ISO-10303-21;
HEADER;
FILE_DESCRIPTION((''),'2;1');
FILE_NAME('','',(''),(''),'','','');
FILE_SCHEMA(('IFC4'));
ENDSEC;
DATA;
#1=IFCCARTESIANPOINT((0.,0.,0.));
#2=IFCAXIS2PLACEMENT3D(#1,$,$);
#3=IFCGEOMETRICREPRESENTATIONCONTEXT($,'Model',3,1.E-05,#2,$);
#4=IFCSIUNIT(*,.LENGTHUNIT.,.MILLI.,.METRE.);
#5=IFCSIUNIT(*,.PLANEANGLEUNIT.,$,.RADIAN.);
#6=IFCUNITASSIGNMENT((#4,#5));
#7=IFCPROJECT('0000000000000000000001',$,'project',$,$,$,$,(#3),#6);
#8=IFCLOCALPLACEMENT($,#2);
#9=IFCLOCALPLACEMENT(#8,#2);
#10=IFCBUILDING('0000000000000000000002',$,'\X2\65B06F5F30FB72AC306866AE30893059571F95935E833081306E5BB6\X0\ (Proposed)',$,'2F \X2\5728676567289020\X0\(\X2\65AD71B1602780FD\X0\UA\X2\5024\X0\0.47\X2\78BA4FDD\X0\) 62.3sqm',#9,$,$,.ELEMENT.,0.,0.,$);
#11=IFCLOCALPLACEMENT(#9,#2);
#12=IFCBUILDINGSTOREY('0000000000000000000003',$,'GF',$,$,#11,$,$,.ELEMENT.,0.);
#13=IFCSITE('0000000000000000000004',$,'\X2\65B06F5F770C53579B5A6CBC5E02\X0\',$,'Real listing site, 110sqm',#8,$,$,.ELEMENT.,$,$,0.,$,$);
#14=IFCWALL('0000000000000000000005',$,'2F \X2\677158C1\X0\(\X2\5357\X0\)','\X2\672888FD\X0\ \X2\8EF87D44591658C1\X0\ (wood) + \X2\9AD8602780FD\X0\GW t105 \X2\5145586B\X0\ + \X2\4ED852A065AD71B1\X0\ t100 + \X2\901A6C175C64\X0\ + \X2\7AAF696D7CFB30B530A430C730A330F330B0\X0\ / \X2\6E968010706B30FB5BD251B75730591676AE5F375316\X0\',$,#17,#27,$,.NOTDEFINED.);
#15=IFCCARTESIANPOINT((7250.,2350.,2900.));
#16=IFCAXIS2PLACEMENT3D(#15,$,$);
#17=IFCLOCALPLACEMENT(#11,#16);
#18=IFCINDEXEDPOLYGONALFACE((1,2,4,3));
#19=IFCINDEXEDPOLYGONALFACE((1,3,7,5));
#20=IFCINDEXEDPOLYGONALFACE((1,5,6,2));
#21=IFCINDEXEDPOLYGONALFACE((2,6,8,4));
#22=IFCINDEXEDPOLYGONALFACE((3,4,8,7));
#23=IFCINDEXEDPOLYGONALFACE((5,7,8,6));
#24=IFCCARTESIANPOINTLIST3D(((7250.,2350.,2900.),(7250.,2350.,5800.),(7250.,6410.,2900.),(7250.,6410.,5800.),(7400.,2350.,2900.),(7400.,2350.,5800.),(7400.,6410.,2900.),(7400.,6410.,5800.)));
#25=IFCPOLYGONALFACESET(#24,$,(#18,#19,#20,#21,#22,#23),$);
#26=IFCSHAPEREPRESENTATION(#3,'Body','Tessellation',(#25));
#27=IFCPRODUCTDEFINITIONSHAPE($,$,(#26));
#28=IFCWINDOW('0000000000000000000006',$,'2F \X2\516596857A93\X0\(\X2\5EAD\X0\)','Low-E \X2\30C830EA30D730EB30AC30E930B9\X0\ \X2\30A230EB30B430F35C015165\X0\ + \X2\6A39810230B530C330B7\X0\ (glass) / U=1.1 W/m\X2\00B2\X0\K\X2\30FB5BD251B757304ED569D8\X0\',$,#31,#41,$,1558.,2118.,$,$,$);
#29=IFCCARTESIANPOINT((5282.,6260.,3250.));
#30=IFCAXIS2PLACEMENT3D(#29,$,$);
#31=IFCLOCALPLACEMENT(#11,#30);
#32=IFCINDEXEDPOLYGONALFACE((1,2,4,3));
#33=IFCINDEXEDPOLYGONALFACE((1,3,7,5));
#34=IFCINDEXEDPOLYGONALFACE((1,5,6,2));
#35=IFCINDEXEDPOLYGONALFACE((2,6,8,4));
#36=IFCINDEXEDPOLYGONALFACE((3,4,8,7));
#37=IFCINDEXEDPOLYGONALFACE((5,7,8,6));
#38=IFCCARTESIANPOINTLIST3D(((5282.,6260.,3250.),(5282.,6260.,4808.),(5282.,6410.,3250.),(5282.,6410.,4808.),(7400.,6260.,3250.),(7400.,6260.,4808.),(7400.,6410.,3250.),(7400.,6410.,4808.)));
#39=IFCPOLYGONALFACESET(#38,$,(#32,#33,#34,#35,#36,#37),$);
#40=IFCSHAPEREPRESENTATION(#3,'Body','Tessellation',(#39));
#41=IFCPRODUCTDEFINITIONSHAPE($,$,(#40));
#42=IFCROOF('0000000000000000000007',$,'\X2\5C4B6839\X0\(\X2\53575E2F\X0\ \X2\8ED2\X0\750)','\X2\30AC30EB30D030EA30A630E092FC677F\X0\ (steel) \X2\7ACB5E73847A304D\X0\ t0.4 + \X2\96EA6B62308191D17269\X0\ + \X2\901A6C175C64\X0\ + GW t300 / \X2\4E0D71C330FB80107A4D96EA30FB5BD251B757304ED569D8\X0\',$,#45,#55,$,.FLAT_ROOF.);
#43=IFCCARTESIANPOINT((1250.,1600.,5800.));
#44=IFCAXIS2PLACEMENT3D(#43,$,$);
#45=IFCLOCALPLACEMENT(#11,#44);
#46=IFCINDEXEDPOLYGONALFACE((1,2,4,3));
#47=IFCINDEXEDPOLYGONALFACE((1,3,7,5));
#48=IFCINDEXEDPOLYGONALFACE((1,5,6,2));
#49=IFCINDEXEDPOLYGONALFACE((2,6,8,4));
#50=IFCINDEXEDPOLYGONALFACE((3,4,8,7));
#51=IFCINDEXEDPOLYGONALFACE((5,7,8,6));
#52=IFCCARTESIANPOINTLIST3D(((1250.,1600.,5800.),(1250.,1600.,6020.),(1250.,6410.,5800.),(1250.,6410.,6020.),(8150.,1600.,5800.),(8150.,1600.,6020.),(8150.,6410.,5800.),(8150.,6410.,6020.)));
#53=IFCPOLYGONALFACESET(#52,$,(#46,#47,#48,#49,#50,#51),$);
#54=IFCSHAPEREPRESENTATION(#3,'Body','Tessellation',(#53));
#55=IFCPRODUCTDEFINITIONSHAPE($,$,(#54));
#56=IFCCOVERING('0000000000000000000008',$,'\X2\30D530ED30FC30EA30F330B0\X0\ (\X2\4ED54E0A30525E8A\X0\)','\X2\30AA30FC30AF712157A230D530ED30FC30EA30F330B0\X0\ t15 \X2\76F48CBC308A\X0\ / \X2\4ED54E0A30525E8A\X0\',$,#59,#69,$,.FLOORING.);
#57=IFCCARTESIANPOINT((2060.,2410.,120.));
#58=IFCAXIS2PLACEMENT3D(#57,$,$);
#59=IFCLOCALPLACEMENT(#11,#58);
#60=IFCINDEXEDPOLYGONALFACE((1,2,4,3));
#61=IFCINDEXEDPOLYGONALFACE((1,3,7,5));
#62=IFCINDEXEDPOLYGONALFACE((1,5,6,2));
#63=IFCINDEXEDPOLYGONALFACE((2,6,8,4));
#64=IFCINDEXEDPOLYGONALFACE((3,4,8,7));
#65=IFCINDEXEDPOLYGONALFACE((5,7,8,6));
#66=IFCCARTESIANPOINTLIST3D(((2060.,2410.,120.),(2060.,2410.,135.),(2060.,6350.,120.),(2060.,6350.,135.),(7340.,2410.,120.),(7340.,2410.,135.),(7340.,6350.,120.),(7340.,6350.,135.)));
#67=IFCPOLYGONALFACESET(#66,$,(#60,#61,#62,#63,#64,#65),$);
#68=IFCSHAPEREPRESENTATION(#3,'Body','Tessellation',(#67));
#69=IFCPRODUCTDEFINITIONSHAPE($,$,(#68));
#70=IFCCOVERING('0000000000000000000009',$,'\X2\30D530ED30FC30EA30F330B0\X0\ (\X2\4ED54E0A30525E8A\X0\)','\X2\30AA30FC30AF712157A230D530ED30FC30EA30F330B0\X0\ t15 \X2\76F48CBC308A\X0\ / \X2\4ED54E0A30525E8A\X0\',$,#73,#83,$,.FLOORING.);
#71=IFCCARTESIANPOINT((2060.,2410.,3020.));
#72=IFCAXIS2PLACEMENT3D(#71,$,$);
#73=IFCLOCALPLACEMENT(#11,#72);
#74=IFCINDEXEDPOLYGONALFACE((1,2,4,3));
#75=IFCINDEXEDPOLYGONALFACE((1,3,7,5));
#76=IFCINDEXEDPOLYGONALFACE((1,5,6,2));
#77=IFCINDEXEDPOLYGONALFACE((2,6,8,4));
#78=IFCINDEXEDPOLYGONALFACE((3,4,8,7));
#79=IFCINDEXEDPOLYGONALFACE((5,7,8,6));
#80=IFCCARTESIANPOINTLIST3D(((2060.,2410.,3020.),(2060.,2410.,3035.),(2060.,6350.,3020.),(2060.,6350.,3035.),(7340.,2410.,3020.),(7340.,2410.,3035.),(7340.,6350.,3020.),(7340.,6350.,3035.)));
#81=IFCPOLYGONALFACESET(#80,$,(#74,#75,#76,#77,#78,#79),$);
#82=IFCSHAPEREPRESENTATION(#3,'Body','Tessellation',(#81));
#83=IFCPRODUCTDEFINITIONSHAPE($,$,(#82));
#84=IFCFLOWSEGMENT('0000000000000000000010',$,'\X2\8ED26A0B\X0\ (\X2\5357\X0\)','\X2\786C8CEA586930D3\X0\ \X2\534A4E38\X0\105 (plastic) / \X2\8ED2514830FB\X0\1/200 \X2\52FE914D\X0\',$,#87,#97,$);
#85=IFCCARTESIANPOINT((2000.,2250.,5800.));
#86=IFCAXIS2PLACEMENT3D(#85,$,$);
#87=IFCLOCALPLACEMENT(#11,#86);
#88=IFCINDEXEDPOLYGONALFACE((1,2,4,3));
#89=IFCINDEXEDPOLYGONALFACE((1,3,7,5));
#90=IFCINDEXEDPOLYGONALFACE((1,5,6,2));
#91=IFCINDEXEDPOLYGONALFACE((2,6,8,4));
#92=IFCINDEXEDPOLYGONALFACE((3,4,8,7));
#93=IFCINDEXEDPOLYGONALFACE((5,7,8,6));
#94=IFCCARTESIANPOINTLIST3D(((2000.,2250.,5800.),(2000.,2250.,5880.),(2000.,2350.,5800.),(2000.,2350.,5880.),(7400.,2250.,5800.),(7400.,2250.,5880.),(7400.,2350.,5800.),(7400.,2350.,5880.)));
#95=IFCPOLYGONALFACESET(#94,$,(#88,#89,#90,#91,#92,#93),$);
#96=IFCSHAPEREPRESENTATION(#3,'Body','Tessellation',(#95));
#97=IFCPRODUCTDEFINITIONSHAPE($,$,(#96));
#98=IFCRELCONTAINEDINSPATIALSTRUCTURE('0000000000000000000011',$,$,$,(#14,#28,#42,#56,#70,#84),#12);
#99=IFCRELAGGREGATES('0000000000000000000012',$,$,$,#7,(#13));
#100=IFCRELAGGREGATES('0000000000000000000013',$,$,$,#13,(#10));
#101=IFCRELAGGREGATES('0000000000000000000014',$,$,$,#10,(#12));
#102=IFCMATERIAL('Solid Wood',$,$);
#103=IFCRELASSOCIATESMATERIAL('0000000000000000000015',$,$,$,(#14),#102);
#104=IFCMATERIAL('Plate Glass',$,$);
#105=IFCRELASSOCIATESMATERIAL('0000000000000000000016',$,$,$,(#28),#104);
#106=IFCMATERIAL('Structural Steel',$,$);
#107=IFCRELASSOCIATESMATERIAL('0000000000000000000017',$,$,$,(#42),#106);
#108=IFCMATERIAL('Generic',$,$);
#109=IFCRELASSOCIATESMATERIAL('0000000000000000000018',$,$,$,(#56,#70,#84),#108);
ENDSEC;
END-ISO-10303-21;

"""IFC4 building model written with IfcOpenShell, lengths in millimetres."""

from ifc_helpers import new_model, si_unit, frame, frame_2d, origin, place, context, project, spatial, rectangle, extrude, material, element, fill, save


model = new_model("IFC4")

# Units and contexts
model_context = context("Model", 3, precision=1e-05, world=origin())
ifc_project = project(units=[si_unit("LENGTHUNIT", "METRE", prefix="MILLI"), si_unit("PLANEANGLEUNIT", "RADIAN")], contexts=[model_context])

# Site, building, storey
site_placement = place(None, origin())
site = spatial("IfcSite", under=ifc_project, at=site_placement, Name="新潟県南魚沼市", ObjectType="Real listing site, 110sqm", CompositionType="ELEMENT", RefElevation=0.0)
building_placement = place(site_placement, origin())
building = spatial("IfcBuilding", under=site, at=building_placement, Name="新潟・犬と暮らす土間広めの家 (Proposed)", ObjectType="2F 在来木造(断熱性能UA値0.47確保) 62.3sqm", CompositionType="ELEMENT", ElevationOfRefHeight=0.0, ElevationOfTerrain=0.0)
storey_placement = place(building_placement, origin())
storey = spatial("IfcBuildingStorey", under=building, at=storey_placement, Name="GF", CompositionType="ELEMENT", Elevation=0.0)

# Shared definitions
ifc_material_1 = material(Name="Solid Wood")

# Shared definitions
ifc_material_2 = material(Name="Plate Glass")

# Wall, opening, window
wall_1_placement = place(storey_placement, frame((7250.0, 2350.0, 2900.0)))
wall_1 = element("IfcWall", 1, at=wall_1_placement, inside=storey, material=ifc_material_1, Name="2F 東壁(南)", Description="木製 軸組外壁 (wood) + 高性能GW t105 充填 + 付加断熱 t100 + 通気層 + 窯業系サイディング / 準耐火・寒冷地外皮強化", PredefinedType="NOTDEFINED", context=model_context, shape_type="SweptSolid", body=[
    extrude(rectangle(XDim=150.0, YDim=4060.0, at=frame_2d((75.0, 2030.0))), frame((7250.0, 2350.0, 2900.0)), (0.0, 0.0, 1.0), 2900.0),
])
opening_1_placement = place(storey_placement, frame((5282.0, 6260.0, 3250.0)))
opening_1 = element("IfcOpeningElement", 2, at=opening_1_placement, cuts=wall_1, PredefinedType="NOTDEFINED", context=model_context, shape_type="SweptSolid", body=[
    extrude(rectangle(XDim=2118.0, YDim=150.0, at=frame_2d((1059.0, 75.0))), frame((5282.0, 6260.0, 3250.0)), (0.0, 0.0, 1.0), 1558.0),
])
window_1_placement = place(storey_placement, frame((5282.0, 6260.0, 3250.0)))
window_1 = element("IfcWindow", 3, at=window_1_placement, inside=storey, material=ifc_material_2, Name="2F 入隅窓(庭)", Description="Low-E トリプルガラス アルゴン封入 + 樹脂サッシ (glass) / U=1.1 W/m²K・寒冷地仕様", OverallHeight=1558.0, OverallWidth=2118.0, context=model_context, shape_type="SweptSolid", body=[
    extrude(rectangle(XDim=2118.0, YDim=150.0, at=frame_2d((1059.0, 75.0))), frame((5282.0, 6260.0, 3250.0)), (0.0, 0.0, 1.0), 1558.0),
])
fill(opening_1, window_1)

# Roof
ifc_material_3 = material(Name="Structural Steel")
for number, where, name in (
    (4, (1250.0, 1600.0, 5800.0), "屋根(南帯 軒750)"),
):
    element("IfcRoof", number, at=place(storey_placement, frame(where)), inside=storey, material=ifc_material_3, Name=name, Description="ガルバリウム鋼板 (steel) 立平葺き t0.4 + 雪止め金物 + 通気層 + GW t300 / 不燃・耐積雪・寒冷地仕様", PredefinedType="FLAT_ROOF", context=model_context, shape_type="SweptSolid", body=[
        extrude(rectangle(XDim=6900.0, YDim=4810.0, at=frame_2d((3450.0, 2405.0))), frame((1250.0, 1600.0, 5800.0)), (0.0, 0.0, 1.0), 220.0),
    ])

# Coverings
ifc_material_4 = material(Name="Generic")
covering_1_placement = place(storey_placement, frame((2060.0, 2410.0, 120.0)))
element("IfcCovering", 5, at=covering_1_placement, inside=storey, material=ifc_material_4, Name="フローリング (仕上げ床)", Description="オーク無垢フローリング t15 直貼り / 仕上げ床", PredefinedType="FLOORING", context=model_context, shape_type="SweptSolid", body=[
    extrude(rectangle(XDim=5280.0, YDim=3940.0, at=frame_2d((2640.0, 1970.0))), frame((2060.0, 2410.0, 120.0)), (0.0, 0.0, 1.0), 15.0),
])
covering_2_placement = place(storey_placement, frame((2060.0, 2410.0, 3020.0)))
element("IfcCovering", 6, at=covering_2_placement, inside=storey, material=ifc_material_4, Name="フローリング (仕上げ床)", Description="オーク無垢フローリング t15 直貼り / 仕上げ床", PredefinedType="FLOORING", context=model_context, shape_type="SweptSolid", body=[
    extrude(rectangle(XDim=5280.0, YDim=3940.0, at=frame_2d((2640.0, 1970.0))), frame((2060.0, 2410.0, 3020.0)), (0.0, 0.0, 1.0), 15.0),
])

# Flow segment
flow_segment_placement = place(storey_placement, frame((2000.0, 2250.0, 5800.0)))
element("IfcFlowSegment", 7, at=flow_segment_placement, inside=storey, material=ifc_material_4, Name="軒樋 (南)", Description="硬質塩ビ 半丸105 (plastic) / 軒先・1/200 勾配", context=model_context, shape_type="SweptSolid", body=[
    extrude(rectangle(XDim=5400.0, YDim=100.0, at=frame_2d((2700.0, 50.0))), frame((2000.0, 2250.0, 5800.0)), (0.0, 0.0, 1.0), 80.0),
])

save(model, "model.ifc")
